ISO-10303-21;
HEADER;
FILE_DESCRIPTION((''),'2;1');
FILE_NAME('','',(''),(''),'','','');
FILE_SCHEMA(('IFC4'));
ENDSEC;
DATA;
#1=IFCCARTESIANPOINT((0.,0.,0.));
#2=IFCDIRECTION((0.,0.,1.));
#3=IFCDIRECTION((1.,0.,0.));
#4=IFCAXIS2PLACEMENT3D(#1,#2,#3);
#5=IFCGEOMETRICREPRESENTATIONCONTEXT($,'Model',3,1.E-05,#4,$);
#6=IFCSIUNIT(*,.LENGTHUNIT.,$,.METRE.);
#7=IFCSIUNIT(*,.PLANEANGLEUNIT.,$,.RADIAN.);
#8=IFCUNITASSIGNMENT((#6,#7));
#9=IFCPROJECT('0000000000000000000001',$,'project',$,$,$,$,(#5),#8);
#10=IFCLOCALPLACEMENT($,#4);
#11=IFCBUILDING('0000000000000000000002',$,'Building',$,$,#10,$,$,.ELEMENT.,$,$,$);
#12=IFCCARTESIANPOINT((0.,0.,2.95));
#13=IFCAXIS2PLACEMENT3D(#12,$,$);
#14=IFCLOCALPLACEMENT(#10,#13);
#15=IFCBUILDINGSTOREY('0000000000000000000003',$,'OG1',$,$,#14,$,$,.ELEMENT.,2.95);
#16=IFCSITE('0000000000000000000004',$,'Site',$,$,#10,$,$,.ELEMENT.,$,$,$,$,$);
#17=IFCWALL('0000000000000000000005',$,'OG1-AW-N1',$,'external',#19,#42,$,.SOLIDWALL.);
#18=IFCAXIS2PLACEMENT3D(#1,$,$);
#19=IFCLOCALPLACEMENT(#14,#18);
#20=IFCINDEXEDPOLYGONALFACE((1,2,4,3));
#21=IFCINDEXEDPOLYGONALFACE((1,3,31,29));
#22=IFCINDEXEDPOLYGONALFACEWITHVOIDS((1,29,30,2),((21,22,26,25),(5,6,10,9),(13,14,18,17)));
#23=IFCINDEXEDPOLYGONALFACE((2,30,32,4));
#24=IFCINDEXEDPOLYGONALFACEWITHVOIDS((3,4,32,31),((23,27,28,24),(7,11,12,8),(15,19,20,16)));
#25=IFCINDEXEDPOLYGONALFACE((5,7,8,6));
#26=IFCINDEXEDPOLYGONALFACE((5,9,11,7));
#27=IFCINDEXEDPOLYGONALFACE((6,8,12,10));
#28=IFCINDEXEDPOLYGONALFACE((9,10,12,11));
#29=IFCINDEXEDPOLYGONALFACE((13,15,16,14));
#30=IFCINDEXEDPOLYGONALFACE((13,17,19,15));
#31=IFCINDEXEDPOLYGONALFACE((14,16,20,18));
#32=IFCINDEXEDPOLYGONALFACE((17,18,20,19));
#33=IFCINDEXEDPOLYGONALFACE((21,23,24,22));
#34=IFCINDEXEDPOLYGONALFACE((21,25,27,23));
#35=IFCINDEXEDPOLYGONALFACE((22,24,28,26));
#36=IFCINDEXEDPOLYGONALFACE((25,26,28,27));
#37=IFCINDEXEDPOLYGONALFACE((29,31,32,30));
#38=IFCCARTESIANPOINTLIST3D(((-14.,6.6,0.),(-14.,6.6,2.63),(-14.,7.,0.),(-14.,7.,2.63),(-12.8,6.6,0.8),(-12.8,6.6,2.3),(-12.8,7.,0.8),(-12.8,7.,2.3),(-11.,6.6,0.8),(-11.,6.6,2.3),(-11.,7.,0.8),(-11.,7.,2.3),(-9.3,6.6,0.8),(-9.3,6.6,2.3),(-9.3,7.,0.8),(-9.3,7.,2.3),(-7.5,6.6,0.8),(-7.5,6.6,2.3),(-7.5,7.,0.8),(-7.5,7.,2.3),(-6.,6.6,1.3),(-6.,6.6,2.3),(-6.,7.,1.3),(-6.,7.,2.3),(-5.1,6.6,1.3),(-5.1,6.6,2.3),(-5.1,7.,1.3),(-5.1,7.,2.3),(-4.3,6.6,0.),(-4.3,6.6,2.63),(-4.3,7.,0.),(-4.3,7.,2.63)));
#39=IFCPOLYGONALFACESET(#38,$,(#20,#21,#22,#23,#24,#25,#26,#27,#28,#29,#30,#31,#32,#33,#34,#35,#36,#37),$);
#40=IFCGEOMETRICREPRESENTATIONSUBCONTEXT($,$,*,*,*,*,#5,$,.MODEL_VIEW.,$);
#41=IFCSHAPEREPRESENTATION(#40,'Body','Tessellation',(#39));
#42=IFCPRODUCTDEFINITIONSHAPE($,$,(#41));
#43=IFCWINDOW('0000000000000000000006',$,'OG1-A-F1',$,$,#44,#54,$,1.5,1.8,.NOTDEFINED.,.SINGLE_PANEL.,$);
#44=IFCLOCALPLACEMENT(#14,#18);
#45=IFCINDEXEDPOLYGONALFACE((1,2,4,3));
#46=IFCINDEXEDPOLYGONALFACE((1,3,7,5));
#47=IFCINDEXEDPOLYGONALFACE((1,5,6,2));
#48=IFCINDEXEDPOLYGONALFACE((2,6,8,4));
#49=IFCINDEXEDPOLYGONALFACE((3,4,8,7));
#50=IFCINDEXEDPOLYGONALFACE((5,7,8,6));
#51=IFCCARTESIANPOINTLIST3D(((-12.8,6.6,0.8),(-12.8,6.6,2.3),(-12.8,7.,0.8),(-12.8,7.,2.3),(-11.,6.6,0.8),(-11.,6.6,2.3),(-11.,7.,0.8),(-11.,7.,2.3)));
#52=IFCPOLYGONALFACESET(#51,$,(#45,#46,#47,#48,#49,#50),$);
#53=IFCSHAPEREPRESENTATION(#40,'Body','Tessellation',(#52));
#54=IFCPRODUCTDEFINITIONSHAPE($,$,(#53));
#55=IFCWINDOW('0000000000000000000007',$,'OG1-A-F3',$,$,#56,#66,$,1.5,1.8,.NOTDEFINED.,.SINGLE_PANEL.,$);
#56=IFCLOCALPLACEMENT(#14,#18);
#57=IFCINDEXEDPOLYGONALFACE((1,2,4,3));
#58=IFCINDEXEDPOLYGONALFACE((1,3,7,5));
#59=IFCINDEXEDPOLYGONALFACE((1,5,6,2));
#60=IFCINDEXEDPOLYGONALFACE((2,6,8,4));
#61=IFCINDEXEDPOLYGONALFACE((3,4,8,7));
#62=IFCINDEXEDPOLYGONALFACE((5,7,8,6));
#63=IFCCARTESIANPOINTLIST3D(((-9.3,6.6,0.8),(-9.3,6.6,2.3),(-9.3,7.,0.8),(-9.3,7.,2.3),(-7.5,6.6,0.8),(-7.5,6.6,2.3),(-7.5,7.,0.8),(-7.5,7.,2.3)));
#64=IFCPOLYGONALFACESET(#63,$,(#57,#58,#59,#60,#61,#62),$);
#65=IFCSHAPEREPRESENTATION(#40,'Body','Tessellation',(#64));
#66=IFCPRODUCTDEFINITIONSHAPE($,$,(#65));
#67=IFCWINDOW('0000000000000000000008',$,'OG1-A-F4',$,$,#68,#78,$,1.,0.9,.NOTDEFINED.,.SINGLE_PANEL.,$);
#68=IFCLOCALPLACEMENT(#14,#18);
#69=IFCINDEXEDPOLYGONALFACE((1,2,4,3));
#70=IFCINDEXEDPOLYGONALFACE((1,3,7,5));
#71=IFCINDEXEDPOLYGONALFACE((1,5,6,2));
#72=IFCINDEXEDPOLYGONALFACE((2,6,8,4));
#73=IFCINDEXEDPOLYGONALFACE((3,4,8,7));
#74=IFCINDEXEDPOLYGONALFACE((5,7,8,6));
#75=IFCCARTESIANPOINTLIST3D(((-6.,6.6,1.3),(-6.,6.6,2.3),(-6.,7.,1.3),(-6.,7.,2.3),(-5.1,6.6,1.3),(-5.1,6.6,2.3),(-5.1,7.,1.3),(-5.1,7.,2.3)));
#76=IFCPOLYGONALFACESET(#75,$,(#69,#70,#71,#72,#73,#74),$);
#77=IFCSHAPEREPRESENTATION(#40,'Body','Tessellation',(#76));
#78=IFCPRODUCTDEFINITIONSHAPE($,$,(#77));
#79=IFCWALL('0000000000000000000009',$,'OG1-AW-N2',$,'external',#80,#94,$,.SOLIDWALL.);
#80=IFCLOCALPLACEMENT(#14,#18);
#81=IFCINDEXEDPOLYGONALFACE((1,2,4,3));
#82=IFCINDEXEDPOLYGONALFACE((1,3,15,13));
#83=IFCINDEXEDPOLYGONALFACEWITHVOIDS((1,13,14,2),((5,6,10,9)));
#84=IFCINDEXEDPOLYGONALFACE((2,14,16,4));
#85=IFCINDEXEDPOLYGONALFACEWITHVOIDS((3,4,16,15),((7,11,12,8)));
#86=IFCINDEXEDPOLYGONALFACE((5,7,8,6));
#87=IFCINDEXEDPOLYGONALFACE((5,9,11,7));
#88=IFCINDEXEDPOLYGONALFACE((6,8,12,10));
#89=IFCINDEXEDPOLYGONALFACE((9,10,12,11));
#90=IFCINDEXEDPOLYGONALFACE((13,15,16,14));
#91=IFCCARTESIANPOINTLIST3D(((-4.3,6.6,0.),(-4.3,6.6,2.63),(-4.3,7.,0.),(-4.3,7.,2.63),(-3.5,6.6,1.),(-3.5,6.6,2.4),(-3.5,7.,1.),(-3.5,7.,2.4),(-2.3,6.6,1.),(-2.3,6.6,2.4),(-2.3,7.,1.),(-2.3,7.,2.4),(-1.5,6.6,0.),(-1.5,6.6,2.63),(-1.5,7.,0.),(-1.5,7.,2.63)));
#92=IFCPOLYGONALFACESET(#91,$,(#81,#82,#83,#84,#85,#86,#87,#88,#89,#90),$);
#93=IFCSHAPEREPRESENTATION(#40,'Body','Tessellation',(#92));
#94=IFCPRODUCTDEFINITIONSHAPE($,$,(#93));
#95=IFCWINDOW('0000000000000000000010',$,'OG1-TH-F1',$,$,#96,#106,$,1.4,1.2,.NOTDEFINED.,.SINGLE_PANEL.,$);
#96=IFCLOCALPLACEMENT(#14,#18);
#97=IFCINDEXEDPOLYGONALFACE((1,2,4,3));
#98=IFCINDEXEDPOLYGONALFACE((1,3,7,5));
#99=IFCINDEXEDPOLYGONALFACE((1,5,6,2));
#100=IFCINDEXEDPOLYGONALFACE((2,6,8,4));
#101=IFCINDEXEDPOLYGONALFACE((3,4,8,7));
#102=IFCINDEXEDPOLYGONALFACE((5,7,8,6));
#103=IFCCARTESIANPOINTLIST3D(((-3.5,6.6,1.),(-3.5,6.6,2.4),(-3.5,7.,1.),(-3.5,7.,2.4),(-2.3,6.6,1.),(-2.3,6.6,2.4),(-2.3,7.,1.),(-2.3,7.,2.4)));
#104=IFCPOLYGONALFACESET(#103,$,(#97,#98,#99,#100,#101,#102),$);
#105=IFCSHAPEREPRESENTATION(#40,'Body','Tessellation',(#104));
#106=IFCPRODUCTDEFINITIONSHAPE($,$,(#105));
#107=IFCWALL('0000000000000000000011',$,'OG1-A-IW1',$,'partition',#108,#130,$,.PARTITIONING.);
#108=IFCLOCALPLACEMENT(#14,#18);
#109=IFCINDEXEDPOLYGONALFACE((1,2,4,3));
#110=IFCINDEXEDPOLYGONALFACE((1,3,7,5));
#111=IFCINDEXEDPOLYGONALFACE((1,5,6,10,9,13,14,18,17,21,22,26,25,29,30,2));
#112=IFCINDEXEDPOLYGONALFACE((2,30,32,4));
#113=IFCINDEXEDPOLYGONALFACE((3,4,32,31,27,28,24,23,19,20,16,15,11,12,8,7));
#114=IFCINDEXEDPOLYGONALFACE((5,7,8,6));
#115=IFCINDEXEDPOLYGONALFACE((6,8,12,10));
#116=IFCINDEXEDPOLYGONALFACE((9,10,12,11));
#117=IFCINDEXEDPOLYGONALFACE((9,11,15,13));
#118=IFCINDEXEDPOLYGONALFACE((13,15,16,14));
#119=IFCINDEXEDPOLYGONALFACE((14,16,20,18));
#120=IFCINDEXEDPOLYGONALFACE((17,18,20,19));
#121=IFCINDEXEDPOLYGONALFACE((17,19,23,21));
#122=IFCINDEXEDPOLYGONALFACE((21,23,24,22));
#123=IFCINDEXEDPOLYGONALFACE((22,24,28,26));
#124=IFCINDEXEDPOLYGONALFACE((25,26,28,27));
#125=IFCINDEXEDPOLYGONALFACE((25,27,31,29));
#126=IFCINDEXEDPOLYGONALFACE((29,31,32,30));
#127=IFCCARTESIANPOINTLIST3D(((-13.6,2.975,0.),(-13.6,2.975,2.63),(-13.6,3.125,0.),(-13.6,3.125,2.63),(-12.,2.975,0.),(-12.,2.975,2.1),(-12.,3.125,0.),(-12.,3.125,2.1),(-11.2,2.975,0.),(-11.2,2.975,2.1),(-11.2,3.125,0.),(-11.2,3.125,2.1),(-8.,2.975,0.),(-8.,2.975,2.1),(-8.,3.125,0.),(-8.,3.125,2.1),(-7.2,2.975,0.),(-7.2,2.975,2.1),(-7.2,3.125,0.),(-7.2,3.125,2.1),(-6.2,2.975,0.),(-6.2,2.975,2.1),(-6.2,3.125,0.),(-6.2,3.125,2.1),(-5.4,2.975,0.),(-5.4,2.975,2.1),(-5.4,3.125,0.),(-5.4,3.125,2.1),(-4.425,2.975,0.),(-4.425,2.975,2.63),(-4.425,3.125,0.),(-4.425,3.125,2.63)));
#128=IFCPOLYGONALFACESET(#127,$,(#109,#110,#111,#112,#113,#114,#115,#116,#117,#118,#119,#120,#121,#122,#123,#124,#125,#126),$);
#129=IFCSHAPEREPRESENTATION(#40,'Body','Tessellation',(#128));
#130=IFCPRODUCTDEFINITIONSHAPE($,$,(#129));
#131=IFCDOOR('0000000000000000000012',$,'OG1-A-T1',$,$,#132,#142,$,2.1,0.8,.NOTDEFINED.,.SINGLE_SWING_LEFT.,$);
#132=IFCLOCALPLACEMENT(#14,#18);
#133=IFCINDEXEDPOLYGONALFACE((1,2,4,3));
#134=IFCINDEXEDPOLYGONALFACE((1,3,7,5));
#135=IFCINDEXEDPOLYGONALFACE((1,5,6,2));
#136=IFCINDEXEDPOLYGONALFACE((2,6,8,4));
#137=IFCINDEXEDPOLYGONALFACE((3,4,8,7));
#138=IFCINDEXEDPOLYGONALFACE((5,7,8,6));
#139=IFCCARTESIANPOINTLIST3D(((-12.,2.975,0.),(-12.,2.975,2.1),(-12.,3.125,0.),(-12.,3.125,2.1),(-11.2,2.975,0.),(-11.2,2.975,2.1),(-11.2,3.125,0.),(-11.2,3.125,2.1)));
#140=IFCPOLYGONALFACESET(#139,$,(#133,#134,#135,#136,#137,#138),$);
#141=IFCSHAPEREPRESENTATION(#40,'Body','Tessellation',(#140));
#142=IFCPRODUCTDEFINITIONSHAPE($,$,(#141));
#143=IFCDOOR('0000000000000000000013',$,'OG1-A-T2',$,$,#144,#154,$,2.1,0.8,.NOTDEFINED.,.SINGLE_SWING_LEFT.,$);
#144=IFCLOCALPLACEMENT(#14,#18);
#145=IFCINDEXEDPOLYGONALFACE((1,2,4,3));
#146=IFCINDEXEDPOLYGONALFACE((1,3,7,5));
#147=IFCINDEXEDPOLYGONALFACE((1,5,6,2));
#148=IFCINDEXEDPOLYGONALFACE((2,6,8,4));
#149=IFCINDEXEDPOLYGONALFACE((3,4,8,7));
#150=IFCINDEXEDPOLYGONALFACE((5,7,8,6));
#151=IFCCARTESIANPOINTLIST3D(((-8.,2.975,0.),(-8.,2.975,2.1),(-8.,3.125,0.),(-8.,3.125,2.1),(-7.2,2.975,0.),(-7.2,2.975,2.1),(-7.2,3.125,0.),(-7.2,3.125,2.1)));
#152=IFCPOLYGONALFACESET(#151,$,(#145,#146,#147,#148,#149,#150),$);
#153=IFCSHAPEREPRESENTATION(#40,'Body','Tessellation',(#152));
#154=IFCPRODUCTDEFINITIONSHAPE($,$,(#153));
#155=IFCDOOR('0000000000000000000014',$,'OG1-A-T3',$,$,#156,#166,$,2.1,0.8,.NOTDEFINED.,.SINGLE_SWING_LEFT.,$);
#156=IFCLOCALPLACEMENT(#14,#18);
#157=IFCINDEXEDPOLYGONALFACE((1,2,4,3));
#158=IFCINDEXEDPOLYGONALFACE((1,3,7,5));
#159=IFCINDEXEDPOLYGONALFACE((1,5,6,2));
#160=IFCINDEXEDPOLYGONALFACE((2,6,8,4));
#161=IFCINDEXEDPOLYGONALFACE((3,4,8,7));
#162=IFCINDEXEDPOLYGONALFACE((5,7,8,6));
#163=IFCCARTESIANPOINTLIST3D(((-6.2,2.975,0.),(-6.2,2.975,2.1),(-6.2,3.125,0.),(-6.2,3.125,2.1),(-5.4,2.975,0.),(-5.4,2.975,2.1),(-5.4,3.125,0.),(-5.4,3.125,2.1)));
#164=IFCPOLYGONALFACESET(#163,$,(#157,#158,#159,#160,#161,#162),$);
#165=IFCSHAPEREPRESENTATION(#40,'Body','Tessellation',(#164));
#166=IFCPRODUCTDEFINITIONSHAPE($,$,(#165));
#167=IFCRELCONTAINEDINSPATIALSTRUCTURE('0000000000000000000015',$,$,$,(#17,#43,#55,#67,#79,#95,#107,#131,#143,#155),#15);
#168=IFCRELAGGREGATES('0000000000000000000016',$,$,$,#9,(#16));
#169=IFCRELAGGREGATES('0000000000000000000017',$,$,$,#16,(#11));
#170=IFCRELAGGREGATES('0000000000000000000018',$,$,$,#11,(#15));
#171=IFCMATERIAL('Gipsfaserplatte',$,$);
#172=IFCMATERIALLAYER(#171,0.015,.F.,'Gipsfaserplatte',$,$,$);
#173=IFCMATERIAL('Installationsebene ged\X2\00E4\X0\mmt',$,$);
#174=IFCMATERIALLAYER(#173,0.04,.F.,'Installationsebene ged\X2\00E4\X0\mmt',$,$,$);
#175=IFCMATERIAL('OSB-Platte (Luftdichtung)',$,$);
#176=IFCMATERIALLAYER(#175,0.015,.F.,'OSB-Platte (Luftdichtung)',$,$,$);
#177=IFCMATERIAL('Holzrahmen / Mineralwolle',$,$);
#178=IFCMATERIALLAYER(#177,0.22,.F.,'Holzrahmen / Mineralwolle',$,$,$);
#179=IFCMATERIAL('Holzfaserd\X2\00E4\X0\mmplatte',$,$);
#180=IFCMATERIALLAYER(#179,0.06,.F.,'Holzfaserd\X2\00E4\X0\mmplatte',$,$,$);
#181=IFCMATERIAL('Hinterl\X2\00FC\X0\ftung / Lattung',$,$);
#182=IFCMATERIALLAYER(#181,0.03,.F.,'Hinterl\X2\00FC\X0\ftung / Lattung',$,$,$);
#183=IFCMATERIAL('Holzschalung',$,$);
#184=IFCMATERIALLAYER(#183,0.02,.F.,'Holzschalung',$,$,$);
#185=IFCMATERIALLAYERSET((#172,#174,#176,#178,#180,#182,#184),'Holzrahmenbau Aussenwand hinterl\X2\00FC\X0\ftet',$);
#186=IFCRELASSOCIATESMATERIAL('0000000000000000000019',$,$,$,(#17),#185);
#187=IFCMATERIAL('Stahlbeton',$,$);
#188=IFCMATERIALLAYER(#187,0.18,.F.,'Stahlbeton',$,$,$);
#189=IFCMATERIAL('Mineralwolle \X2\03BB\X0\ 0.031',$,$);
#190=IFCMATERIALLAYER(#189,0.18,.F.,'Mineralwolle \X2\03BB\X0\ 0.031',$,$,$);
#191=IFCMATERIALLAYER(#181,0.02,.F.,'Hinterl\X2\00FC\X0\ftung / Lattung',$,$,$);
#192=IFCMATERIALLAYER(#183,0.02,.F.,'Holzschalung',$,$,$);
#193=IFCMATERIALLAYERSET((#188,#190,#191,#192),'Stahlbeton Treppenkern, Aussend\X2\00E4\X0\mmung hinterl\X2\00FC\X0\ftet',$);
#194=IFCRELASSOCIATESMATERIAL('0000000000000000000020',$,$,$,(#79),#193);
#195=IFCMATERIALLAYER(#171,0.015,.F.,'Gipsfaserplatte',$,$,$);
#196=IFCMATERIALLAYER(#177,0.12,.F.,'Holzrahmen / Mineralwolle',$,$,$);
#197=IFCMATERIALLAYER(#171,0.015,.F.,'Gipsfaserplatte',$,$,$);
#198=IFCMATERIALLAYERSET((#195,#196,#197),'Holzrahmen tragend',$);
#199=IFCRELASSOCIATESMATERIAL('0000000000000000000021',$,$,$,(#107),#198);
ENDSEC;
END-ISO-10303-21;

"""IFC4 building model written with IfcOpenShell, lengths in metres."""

from ifc_helpers import new_model, si_unit, frame, frame_2d, origin, origin_with_axes, place, context, subcontext, project, spatial, rectangle, extrude, material, layer, layer_set, element, fill, save


model = new_model("IFC4")

# Units and contexts
model_context = context("Model", 3, precision=1e-05, world=origin_with_axes())
sub_context = subcontext(model_context, None, None, "MODEL_VIEW")
ifc_project = project(units=[si_unit("LENGTHUNIT", "METRE"), si_unit("PLANEANGLEUNIT", "RADIAN")], contexts=[model_context])

# Site, building, storey
placement = place(None, origin_with_axes())
site = spatial("IfcSite", under=ifc_project, at=placement, Name="Site", CompositionType="ELEMENT")
building = spatial("IfcBuilding", under=site, at=placement, Name="Building", CompositionType="ELEMENT")
storey_placement = place(placement, frame((0.0, 0.0, 2.95)))
storey = spatial("IfcBuildingStorey", under=building, at=storey_placement, Name="OG1", CompositionType="ELEMENT", Elevation=2.95)

# Wall, openings, windows
ifc_material_1 = material(Name="Gipsfaserplatte")
ifc_layer_1 = layer(ifc_material_1, 0.015, ventilated=False, Name="Gipsfaserplatte")
ifc_material_2 = material(Name="Installationsebene gedämmt")
ifc_layer_2 = layer(ifc_material_2, 0.04, ventilated=False, Name="Installationsebene gedämmt")
ifc_material_3 = material(Name="OSB-Platte (Luftdichtung)")
ifc_layer_3 = layer(ifc_material_3, 0.015, ventilated=False, Name="OSB-Platte (Luftdichtung)")
ifc_material_4 = material(Name="Holzrahmen / Mineralwolle")
ifc_layer_4 = layer(ifc_material_4, 0.22, ventilated=False, Name="Holzrahmen / Mineralwolle")
ifc_material_5 = material(Name="Holzfaserdämmplatte")
ifc_layer_5 = layer(ifc_material_5, 0.06, ventilated=False, Name="Holzfaserdämmplatte")
ifc_material_6 = material(Name="Hinterlüftung / Lattung")
ifc_layer_6 = layer(ifc_material_6, 0.03, ventilated=False, Name="Hinterlüftung / Lattung")
ifc_material_7 = material(Name="Holzschalung")
ifc_layer_7 = layer(ifc_material_7, 0.02, ventilated=False, Name="Holzschalung")
ifc_layer_set_1 = layer_set([ifc_layer_1, ifc_layer_2, ifc_layer_3, ifc_layer_4, ifc_layer_5, ifc_layer_6, ifc_layer_7], Name="Holzrahmenbau Aussenwand hinterlüftet")
wall_1_placement = place(storey_placement, frame((-14.0, 6.8, 0.0), z_axis=(0.0, 0.0, 1.0), x_axis=(1.0, 0.0, 0.0)))
wall_1 = element("IfcWall", 1, at=wall_1_placement, inside=storey, material=ifc_layer_set_1, Name="OG1-AW-N1", ObjectType="external", PredefinedType="SOLIDWALL", context=sub_context, shape_type="SweptSolid", body=[
    extrude(rectangle(XDim=9.7, YDim=0.4, at=frame_2d((4.85, 0.0))), origin(), (0.0, 0.0, 1.0), 2.63),
])
opening_1_placement = place(wall_1_placement, frame((2.1, 0.25, 0.8), z_axis=(0.0, -1.0, 0.0), x_axis=(1.0, 0.0, 0.0)))
opening_1 = element("IfcOpeningElement", 2, at=opening_1_placement, cuts=wall_1, PredefinedType="OPENING", context=sub_context, shape_type="SweptSolid", body=[
    extrude(rectangle(XDim=1.8, YDim=1.5, at=frame_2d((0.0, 0.75))), origin(), (0.0, 0.0, 1.0), 0.5),
])
opening_2_placement = place(wall_1_placement, frame((5.6, 0.25, 0.8), z_axis=(0.0, -1.0, 0.0), x_axis=(1.0, 0.0, 0.0)))
opening_2 = element("IfcOpeningElement", 3, at=opening_2_placement, cuts=wall_1, PredefinedType="OPENING", context=sub_context, shape_type="SweptSolid", body=[
    extrude(rectangle(XDim=1.8, YDim=1.5, at=frame_2d((0.0, 0.75))), origin(), (0.0, 0.0, 1.0), 0.5),
])
opening_3_placement = place(wall_1_placement, frame((8.45, 0.25, 1.3), z_axis=(0.0, -1.0, 0.0), x_axis=(1.0, 0.0, 0.0)))
opening_3 = element("IfcOpeningElement", 4, at=opening_3_placement, cuts=wall_1, PredefinedType="OPENING", context=sub_context, shape_type="SweptSolid", body=[
    extrude(rectangle(XDim=0.9, YDim=1.0, at=frame_2d((0.0, 0.5))), origin(), (0.0, 0.0, 1.0), 0.5),
])
window_1_placement = place(wall_1_placement, frame((2.1, 0.2, 0.8), z_axis=(0.0, -1.0, 0.0), x_axis=(1.0, 0.0, 0.0)))
window_1 = element("IfcWindow", 5, at=window_1_placement, inside=storey, Name="OG1-A-F1", OverallHeight=1.5, OverallWidth=1.8, PartitioningType="SINGLE_PANEL", PredefinedType="NOTDEFINED", context=sub_context, shape_type="SweptSolid", body=[
    extrude(rectangle(XDim=1.8, YDim=1.5, at=frame_2d((0.0, 0.75))), origin(), (0.0, 0.0, 1.0), 0.4),
])
fill(opening_1, window_1)
window_2_placement = place(wall_1_placement, frame((5.6, 0.2, 0.8), z_axis=(0.0, -1.0, 0.0), x_axis=(1.0, 0.0, 0.0)))
window_2 = element("IfcWindow", 6, at=window_2_placement, inside=storey, Name="OG1-A-F3", OverallHeight=1.5, OverallWidth=1.8, PartitioningType="SINGLE_PANEL", PredefinedType="NOTDEFINED", context=sub_context, shape_type="SweptSolid", body=[
    extrude(rectangle(XDim=1.8, YDim=1.5, at=frame_2d((0.0, 0.75))), origin(), (0.0, 0.0, 1.0), 0.4),
])
fill(opening_2, window_2)
window_3_placement = place(wall_1_placement, frame((8.45, 0.2, 1.3), z_axis=(0.0, -1.0, 0.0), x_axis=(1.0, 0.0, 0.0)))
window_3 = element("IfcWindow", 7, at=window_3_placement, inside=storey, Name="OG1-A-F4", OverallHeight=1.0, OverallWidth=0.9, PartitioningType="SINGLE_PANEL", PredefinedType="NOTDEFINED", context=sub_context, shape_type="SweptSolid", body=[
    extrude(rectangle(XDim=0.9, YDim=1.0, at=frame_2d((0.0, 0.5))), origin(), (0.0, 0.0, 1.0), 0.4),
])
fill(opening_3, window_3)

# Wall, opening, window
ifc_material_8 = material(Name="Stahlbeton")
ifc_layer_8 = layer(ifc_material_8, 0.18, ventilated=False, Name="Stahlbeton")
ifc_material_9 = material(Name="Mineralwolle λ 0.031")
ifc_layer_9 = layer(ifc_material_9, 0.18, ventilated=False, Name="Mineralwolle λ 0.031")
ifc_layer_10 = layer(ifc_material_6, 0.02, ventilated=False, Name="Hinterlüftung / Lattung")
ifc_layer_11 = layer(ifc_material_7, 0.02, ventilated=False, Name="Holzschalung")
ifc_layer_set_2 = layer_set([ifc_layer_8, ifc_layer_9, ifc_layer_10, ifc_layer_11], Name="Stahlbeton Treppenkern, Aussendämmung hinterlüftet")
wall_2_placement = place(storey_placement, frame((-4.3, 6.8, 0.0), z_axis=(0.0, 0.0, 1.0), x_axis=(1.0, 0.0, 0.0)))
wall_2 = element("IfcWall", 8, at=wall_2_placement, inside=storey, material=ifc_layer_set_2, Name="OG1-AW-N2", ObjectType="external", PredefinedType="SOLIDWALL", context=sub_context, shape_type="SweptSolid", body=[
    extrude(rectangle(XDim=2.8, YDim=0.4, at=frame_2d((1.4, 0.0))), origin(), (0.0, 0.0, 1.0), 2.63),
])
opening_4_placement = place(wall_2_placement, frame((1.4, 0.25, 1.0), z_axis=(0.0, -1.0, 0.0), x_axis=(1.0, 0.0, 0.0)))
opening_4 = element("IfcOpeningElement", 9, at=opening_4_placement, cuts=wall_2, PredefinedType="OPENING", context=sub_context, shape_type="SweptSolid", body=[
    extrude(rectangle(XDim=1.2, YDim=1.4, at=frame_2d((0.0, 0.7))), origin(), (0.0, 0.0, 1.0), 0.5),
])
window_4_placement = place(wall_2_placement, frame((1.4, 0.2, 1.0), z_axis=(0.0, -1.0, 0.0), x_axis=(1.0, 0.0, 0.0)))
window_4 = element("IfcWindow", 10, at=window_4_placement, inside=storey, Name="OG1-TH-F1", OverallHeight=1.4, OverallWidth=1.2, PartitioningType="SINGLE_PANEL", PredefinedType="NOTDEFINED", context=sub_context, shape_type="SweptSolid", body=[
    extrude(rectangle(XDim=1.2, YDim=1.4, at=frame_2d((0.0, 0.7))), origin(), (0.0, 0.0, 1.0), 0.4),
])
fill(opening_4, window_4)

# Wall, openings, doors
ifc_layer_12 = layer(ifc_material_1, 0.015, ventilated=False, Name="Gipsfaserplatte")
ifc_layer_13 = layer(ifc_material_4, 0.12, ventilated=False, Name="Holzrahmen / Mineralwolle")
ifc_layer_14 = layer(ifc_material_1, 0.015, ventilated=False, Name="Gipsfaserplatte")
ifc_layer_set_3 = layer_set([ifc_layer_12, ifc_layer_13, ifc_layer_14], Name="Holzrahmen tragend")
wall_3_placement = place(storey_placement, frame((-13.6, 3.05, 0.0), z_axis=(0.0, 0.0, 1.0), x_axis=(1.0, 0.0, 0.0)))
wall_3 = element("IfcWall", 11, at=wall_3_placement, inside=storey, material=ifc_layer_set_3, Name="OG1-A-IW1", ObjectType="partition", PredefinedType="PARTITIONING", context=sub_context, shape_type="SweptSolid", body=[
    extrude(rectangle(XDim=9.175, YDim=0.15, at=frame_2d((4.5875, 0.0))), origin(), (0.0, 0.0, 1.0), 2.63),
])
opening_5_placement = place(wall_3_placement, frame((2.0, 0.125, 0.0), z_axis=(0.0, -1.0, 0.0), x_axis=(1.0, 0.0, 0.0)))
opening_5 = element("IfcOpeningElement", 12, at=opening_5_placement, cuts=wall_3, PredefinedType="OPENING", context=sub_context, shape_type="SweptSolid", body=[
    extrude(rectangle(XDim=0.8, YDim=2.1, at=frame_2d((0.0, 1.05))), origin(), (0.0, 0.0, 1.0), 0.25),
])
opening_6_placement = place(wall_3_placement, frame((6.0, 0.125, 0.0), z_axis=(0.0, -1.0, 0.0), x_axis=(1.0, 0.0, 0.0)))
opening_6 = element("IfcOpeningElement", 13, at=opening_6_placement, cuts=wall_3, PredefinedType="OPENING", context=sub_context, shape_type="SweptSolid", body=[
    extrude(rectangle(XDim=0.8, YDim=2.1, at=frame_2d((0.0, 1.05))), origin(), (0.0, 0.0, 1.0), 0.25),
])
opening_7_placement = place(wall_3_placement, frame((7.8, 0.125, 0.0), z_axis=(0.0, -1.0, 0.0), x_axis=(1.0, 0.0, 0.0)))
opening_7 = element("IfcOpeningElement", 14, at=opening_7_placement, cuts=wall_3, PredefinedType="OPENING", context=sub_context, shape_type="SweptSolid", body=[
    extrude(rectangle(XDim=0.8, YDim=2.1, at=frame_2d((0.0, 1.05))), origin(), (0.0, 0.0, 1.0), 0.25),
])
door_1_placement = place(wall_3_placement, frame((2.0, 0.075, 0.0), z_axis=(0.0, -1.0, 0.0), x_axis=(1.0, 0.0, 0.0)))
door_1 = element("IfcDoor", 15, at=door_1_placement, inside=storey, Name="OG1-A-T1", OperationType="SINGLE_SWING_LEFT", OverallHeight=2.1, OverallWidth=0.8, PredefinedType="NOTDEFINED", context=sub_context, shape_type="SweptSolid", body=[
    extrude(rectangle(XDim=0.8, YDim=2.1, at=frame_2d((0.0, 1.05))), origin(), (0.0, 0.0, 1.0), 0.15),
])
fill(opening_5, door_1)
door_2_placement = place(wall_3_placement, frame((6.0, 0.075, 0.0), z_axis=(0.0, -1.0, 0.0), x_axis=(1.0, 0.0, 0.0)))
door_2 = element("IfcDoor", 16, at=door_2_placement, inside=storey, Name="OG1-A-T2", OperationType="SINGLE_SWING_LEFT", OverallHeight=2.1, OverallWidth=0.8, PredefinedType="NOTDEFINED", context=sub_context, shape_type="SweptSolid", body=[
    extrude(rectangle(XDim=0.8, YDim=2.1, at=frame_2d((0.0, 1.05))), origin(), (0.0, 0.0, 1.0), 0.15),
])
fill(opening_6, door_2)
door_3_placement = place(wall_3_placement, frame((7.8, 0.075, 0.0), z_axis=(0.0, -1.0, 0.0), x_axis=(1.0, 0.0, 0.0)))
door_3 = element("IfcDoor", 17, at=door_3_placement, inside=storey, Name="OG1-A-T3", OperationType="SINGLE_SWING_LEFT", OverallHeight=2.1, OverallWidth=0.8, PredefinedType="NOTDEFINED", context=sub_context, shape_type="SweptSolid", body=[
    extrude(rectangle(XDim=0.8, YDim=2.1, at=frame_2d((0.0, 1.05))), origin(), (0.0, 0.0, 1.0), 0.15),
])
fill(opening_7, door_3)

save(model, "model.ifc")
